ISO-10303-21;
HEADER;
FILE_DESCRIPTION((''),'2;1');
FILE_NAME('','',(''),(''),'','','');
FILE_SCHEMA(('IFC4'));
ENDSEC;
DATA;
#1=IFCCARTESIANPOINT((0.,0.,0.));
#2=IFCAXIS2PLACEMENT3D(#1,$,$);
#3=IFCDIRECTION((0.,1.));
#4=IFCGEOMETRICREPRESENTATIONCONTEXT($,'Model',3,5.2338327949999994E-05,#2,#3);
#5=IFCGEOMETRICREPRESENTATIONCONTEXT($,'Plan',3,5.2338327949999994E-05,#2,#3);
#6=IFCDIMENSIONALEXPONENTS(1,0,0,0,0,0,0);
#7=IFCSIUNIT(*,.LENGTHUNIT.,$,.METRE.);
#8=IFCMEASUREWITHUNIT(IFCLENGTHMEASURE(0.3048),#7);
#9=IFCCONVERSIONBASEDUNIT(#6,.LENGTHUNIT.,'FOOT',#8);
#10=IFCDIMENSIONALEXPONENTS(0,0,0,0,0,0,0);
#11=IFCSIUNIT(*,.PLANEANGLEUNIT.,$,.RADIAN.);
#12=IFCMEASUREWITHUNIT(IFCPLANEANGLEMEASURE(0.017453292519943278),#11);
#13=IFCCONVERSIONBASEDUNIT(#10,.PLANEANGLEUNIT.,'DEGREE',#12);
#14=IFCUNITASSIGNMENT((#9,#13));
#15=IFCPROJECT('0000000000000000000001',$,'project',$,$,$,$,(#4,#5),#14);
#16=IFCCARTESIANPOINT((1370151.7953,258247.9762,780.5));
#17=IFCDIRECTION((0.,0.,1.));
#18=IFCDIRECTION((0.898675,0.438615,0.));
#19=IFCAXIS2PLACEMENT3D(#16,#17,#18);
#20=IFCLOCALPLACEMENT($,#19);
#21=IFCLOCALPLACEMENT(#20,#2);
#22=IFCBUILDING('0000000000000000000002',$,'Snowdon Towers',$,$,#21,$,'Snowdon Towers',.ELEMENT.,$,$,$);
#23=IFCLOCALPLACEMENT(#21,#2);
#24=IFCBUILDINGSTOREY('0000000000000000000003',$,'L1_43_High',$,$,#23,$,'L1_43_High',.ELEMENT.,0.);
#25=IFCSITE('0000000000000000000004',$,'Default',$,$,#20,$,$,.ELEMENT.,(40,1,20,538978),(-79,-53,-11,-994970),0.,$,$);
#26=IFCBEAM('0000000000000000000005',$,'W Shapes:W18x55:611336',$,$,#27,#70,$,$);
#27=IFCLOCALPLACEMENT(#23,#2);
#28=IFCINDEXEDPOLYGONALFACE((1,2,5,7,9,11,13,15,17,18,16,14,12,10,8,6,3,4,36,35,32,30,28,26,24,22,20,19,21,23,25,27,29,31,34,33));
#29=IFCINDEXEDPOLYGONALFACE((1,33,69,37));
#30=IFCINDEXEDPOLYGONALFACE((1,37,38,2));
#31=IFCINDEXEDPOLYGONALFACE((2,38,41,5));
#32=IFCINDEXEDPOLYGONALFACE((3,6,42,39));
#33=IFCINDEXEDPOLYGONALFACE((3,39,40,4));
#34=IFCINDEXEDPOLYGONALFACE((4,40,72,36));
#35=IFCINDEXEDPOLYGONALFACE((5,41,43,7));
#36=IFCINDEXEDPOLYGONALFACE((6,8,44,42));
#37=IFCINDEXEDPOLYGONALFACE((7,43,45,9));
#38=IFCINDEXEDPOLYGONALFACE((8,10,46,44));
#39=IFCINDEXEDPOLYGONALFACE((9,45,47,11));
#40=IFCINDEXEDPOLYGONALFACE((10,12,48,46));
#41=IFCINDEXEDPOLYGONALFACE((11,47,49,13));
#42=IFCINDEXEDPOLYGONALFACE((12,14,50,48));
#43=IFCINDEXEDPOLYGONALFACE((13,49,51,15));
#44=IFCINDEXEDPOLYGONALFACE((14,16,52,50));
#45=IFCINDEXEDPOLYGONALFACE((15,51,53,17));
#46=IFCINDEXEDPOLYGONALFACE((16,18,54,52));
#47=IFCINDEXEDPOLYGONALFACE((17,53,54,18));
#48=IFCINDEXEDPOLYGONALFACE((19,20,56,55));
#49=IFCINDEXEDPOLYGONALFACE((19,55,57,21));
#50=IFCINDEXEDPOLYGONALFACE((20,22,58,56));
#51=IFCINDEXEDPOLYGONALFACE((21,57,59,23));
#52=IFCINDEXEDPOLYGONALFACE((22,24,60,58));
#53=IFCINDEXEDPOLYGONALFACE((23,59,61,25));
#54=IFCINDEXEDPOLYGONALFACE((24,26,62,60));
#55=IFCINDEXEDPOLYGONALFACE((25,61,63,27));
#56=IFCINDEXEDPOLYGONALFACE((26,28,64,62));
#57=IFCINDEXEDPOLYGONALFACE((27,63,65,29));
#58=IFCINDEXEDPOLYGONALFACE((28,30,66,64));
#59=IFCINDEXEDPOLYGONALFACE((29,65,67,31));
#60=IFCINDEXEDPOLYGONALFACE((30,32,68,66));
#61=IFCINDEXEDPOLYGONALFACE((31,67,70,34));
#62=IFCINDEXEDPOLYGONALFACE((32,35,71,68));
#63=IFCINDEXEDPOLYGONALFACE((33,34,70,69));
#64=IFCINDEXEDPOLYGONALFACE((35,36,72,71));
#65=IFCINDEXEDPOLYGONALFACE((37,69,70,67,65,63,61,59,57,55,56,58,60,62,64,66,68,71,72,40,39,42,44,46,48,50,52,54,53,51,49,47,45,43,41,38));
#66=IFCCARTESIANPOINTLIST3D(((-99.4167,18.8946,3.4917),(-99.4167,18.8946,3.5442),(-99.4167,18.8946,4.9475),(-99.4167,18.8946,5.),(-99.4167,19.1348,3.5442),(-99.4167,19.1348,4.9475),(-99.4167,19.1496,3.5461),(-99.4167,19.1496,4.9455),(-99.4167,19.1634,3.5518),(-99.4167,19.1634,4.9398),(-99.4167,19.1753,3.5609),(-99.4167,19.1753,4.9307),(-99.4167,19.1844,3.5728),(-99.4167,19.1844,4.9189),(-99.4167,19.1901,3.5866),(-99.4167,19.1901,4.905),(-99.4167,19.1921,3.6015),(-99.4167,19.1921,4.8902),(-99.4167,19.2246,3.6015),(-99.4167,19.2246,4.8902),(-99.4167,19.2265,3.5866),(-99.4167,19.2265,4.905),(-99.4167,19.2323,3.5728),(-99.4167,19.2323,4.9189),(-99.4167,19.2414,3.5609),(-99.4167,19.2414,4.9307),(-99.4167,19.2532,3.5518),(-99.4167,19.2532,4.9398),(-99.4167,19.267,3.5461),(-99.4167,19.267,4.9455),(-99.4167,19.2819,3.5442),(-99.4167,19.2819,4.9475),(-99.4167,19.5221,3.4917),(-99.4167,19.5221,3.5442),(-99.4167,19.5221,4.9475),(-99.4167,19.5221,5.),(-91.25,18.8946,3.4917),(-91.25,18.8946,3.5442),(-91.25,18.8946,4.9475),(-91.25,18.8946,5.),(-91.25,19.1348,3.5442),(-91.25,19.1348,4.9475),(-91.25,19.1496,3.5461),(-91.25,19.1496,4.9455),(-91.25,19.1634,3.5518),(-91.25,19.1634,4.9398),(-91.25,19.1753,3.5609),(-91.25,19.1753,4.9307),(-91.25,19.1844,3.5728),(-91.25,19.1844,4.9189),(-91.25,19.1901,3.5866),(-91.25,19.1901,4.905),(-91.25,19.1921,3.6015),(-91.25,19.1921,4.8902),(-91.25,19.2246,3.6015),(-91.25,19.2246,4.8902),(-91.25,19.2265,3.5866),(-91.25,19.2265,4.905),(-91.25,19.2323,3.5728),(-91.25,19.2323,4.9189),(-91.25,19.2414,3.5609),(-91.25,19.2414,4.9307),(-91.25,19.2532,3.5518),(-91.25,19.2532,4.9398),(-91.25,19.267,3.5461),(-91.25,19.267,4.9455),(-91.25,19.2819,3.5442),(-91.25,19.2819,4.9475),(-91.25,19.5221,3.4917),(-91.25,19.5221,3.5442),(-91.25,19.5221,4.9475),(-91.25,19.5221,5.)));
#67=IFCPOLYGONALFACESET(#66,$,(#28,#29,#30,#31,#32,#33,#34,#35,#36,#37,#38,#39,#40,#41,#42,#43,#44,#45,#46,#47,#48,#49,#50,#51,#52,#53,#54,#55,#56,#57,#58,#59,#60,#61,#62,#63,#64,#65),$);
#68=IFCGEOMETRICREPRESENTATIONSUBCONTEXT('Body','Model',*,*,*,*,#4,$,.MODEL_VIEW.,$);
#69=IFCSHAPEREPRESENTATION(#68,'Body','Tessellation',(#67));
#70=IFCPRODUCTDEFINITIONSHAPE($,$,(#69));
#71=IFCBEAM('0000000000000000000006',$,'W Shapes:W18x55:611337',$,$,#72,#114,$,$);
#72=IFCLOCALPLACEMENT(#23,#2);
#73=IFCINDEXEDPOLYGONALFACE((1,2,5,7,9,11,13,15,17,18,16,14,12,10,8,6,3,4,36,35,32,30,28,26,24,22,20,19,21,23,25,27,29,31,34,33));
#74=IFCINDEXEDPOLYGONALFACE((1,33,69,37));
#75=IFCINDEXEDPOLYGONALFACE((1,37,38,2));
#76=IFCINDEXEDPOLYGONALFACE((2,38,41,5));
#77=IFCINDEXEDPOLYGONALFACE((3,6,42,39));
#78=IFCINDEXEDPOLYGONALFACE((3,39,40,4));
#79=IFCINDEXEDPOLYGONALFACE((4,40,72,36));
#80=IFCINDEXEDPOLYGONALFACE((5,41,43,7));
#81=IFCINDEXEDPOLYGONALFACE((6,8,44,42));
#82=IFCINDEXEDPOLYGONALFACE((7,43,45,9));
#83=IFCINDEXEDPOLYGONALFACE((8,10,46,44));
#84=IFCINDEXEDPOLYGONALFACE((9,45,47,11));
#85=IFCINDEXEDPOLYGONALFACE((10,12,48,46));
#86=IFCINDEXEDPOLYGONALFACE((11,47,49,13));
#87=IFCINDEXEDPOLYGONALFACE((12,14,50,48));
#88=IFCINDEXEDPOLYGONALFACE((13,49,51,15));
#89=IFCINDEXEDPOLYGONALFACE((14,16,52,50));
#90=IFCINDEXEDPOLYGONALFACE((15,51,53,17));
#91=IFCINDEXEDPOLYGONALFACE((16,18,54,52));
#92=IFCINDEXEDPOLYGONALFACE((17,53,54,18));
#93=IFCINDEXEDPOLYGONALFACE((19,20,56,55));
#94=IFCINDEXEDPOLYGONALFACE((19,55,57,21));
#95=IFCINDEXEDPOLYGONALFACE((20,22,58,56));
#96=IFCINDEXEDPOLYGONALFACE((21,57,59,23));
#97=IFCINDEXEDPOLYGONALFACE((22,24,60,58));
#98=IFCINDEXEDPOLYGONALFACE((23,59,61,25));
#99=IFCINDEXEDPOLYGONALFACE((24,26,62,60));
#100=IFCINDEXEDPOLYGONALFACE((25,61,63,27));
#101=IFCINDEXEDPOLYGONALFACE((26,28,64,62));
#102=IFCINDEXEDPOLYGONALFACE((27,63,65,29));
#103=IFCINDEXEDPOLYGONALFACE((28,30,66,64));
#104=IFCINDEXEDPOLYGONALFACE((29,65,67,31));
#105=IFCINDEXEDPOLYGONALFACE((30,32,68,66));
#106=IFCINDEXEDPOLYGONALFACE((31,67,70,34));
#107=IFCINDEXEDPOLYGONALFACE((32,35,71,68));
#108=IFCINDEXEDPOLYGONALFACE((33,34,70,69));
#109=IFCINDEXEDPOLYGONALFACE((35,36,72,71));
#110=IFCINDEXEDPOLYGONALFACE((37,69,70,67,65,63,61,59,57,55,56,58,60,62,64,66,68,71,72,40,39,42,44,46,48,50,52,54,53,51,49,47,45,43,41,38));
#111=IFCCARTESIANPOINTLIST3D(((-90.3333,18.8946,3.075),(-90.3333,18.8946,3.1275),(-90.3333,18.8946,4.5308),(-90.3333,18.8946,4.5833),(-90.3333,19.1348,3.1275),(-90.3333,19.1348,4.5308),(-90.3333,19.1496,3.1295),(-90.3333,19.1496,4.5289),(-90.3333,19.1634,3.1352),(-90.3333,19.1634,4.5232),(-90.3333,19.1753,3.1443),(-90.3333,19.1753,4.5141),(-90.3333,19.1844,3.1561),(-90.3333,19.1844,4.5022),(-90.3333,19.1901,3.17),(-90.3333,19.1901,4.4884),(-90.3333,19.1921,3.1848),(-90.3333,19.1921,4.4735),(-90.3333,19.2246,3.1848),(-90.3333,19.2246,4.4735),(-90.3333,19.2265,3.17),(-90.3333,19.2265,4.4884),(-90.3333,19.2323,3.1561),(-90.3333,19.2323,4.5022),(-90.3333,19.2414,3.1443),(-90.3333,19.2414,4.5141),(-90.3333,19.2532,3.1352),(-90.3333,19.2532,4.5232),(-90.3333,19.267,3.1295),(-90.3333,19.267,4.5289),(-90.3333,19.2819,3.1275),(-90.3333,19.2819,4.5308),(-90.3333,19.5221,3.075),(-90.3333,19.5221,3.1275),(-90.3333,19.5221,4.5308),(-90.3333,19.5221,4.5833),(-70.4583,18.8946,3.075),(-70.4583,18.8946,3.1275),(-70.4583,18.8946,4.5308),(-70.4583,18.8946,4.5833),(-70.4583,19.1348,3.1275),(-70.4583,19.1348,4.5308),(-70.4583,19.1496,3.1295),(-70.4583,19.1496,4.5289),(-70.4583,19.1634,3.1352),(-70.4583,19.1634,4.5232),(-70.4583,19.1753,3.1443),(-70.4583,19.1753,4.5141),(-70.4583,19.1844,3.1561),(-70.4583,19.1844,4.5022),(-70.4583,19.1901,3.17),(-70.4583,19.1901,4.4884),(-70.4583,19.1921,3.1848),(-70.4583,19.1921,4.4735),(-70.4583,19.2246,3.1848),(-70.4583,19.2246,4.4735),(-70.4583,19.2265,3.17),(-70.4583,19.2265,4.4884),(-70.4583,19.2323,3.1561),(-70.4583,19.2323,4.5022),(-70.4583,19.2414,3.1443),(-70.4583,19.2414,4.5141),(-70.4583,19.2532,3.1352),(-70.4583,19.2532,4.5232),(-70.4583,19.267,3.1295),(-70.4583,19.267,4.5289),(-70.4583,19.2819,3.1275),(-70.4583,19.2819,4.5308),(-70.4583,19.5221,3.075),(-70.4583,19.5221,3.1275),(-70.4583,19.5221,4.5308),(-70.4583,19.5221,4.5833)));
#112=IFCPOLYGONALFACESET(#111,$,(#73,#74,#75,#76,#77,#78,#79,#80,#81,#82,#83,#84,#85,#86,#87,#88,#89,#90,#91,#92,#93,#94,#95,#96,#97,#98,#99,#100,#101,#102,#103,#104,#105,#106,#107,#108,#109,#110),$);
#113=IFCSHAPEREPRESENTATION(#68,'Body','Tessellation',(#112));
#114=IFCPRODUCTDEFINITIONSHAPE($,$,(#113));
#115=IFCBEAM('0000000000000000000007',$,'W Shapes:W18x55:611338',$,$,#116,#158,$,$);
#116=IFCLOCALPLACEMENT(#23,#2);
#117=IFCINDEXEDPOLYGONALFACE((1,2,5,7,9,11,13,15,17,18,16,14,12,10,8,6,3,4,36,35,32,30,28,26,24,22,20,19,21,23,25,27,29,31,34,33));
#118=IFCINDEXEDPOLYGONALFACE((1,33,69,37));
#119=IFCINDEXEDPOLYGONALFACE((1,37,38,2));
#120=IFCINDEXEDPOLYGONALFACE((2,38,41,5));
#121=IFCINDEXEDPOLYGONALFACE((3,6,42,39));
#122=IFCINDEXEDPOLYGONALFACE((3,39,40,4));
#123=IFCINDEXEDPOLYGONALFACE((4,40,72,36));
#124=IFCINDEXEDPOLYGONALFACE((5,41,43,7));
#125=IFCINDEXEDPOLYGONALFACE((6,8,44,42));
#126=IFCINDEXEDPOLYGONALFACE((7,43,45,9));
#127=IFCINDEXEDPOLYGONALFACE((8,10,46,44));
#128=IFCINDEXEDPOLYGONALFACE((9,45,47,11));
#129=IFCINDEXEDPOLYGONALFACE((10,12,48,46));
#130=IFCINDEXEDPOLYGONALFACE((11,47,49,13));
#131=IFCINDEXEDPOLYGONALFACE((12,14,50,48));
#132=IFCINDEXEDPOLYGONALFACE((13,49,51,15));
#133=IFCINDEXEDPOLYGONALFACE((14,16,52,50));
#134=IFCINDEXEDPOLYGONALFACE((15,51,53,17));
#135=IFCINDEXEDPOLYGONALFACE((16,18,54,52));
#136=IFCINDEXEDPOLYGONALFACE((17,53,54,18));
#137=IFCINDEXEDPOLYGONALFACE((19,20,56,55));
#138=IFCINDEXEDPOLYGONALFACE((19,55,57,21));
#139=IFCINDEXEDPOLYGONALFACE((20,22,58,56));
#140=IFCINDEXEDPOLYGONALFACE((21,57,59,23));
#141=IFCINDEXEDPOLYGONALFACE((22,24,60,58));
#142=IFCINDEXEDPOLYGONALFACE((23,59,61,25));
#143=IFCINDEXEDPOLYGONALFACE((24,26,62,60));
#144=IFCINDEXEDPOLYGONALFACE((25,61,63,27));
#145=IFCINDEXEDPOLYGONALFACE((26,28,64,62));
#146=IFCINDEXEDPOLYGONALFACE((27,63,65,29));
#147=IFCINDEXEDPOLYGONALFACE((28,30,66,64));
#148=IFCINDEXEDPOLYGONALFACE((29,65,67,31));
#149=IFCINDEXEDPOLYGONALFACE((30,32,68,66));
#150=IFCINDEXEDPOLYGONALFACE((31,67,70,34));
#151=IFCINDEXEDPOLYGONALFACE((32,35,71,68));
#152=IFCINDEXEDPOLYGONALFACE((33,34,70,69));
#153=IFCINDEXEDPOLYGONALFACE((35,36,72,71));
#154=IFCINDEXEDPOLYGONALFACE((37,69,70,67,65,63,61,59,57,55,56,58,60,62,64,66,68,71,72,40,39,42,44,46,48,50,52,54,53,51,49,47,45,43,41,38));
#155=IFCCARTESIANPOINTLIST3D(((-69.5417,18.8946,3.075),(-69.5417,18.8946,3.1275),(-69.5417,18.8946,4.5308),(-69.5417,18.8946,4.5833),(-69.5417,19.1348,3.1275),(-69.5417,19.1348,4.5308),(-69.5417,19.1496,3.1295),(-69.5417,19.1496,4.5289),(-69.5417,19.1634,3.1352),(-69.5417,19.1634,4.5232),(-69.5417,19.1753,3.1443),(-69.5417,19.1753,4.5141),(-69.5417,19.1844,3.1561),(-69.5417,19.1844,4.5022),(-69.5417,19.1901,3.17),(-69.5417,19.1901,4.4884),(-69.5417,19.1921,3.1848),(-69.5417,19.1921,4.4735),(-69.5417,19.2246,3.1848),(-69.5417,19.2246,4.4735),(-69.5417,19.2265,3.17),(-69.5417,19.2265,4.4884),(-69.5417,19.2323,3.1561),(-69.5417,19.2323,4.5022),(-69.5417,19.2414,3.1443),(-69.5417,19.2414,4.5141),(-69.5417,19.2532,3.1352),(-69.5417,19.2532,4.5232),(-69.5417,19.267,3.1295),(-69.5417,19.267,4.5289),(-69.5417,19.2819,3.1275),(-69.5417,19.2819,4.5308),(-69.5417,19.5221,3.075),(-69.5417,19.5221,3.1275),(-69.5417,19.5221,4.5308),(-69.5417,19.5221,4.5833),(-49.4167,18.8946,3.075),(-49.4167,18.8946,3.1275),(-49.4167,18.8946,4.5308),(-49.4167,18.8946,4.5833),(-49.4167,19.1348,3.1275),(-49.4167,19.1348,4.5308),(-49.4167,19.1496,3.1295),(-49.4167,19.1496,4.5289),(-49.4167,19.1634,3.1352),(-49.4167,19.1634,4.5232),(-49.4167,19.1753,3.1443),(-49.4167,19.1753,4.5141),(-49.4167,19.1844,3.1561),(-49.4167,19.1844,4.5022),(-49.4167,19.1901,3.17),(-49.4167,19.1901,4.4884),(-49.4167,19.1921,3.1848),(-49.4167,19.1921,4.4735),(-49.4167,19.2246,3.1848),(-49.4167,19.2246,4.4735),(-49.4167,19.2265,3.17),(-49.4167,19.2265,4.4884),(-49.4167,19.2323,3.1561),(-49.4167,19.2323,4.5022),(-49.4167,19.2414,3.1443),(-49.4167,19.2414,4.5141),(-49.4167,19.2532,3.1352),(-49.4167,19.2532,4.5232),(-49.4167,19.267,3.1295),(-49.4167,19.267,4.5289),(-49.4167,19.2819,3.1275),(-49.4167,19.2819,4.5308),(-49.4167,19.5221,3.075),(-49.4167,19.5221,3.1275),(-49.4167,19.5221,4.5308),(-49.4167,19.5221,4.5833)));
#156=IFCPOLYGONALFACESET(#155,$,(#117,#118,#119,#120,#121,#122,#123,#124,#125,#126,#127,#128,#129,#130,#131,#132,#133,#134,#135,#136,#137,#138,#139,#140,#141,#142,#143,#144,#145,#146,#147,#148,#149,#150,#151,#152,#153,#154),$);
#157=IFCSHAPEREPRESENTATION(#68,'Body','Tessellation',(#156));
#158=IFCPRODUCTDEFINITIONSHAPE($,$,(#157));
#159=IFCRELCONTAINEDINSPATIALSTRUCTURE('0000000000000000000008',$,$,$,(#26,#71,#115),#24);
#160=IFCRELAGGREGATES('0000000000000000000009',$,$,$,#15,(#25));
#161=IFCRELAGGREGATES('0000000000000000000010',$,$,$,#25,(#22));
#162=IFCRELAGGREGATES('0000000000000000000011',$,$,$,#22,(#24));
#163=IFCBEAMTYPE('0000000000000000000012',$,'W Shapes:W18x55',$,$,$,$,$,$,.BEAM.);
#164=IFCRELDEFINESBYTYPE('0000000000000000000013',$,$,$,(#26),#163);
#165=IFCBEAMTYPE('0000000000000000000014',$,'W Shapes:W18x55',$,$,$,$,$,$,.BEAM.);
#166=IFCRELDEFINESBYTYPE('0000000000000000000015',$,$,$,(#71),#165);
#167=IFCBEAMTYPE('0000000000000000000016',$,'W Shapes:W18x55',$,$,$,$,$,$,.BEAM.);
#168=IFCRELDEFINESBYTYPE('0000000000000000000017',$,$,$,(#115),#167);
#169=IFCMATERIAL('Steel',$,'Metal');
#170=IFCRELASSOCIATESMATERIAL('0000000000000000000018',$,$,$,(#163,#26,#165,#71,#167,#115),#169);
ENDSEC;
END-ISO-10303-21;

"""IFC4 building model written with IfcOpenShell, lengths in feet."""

from ifc_helpers import new_model, entity, si_unit, converted_unit, direction, frame, origin, place, context, subcontext, project, spatial, line, arc, indexed_curve, outline, extrude, source, transform, mapped, material, type_object, type_shapes, element, save


model = new_model("IFC4")

# Units and contexts
model_context = context("Model", 3, precision=5.2338327949999994e-05, world=origin(), true_north=direction((0.0, 1.0)))
plan_context = context("Plan", 3, precision=5.2338327949999994e-05, world=origin(), true_north=direction((0.0, 1.0)))
body_context = subcontext(model_context, "Body", "Model", "MODEL_VIEW")
ifc_project = project(units=[converted_unit("LENGTHUNIT", "FOOT", entity("IfcLengthMeasure", 0.3048), si_unit("LENGTHUNIT", "METRE"), dimensions=[1, 0, 0, 0, 0, 0, 0]), converted_unit("PLANEANGLEUNIT", "DEGREE", entity("IfcPlaneAngleMeasure", 0.017453292519943278), si_unit("PLANEANGLEUNIT", "RADIAN"), dimensions=[0, 0, 0, 0, 0, 0, 0])], contexts=[model_context, plan_context])

# Site, building, storey
site_placement = place(None, frame((1370151.7953, 258247.9762, 780.5), z_axis=(0.0, 0.0, 1.0), x_axis=(0.898675, 0.438615, 0.0)))
site = spatial("IfcSite", under=ifc_project, at=site_placement, Name="Default", CompositionType="ELEMENT", RefLatitude=(40, 1, 20, 538978), RefLongitude=(-79, -53, -11, -994970), RefElevation=0.0)
building_placement = place(site_placement, origin())
building = spatial("IfcBuilding", under=site, at=building_placement, Name="Snowdon Towers", LongName="Snowdon Towers", CompositionType="ELEMENT")
storey_placement = place(building_placement, origin())
storey = spatial("IfcBuildingStorey", under=building, at=storey_placement, Name="L1_43_High", LongName="L1_43_High", CompositionType="ELEMENT", Elevation=0.0)

# Shared definitions
ifc_material_1 = material(Name="Steel", Category="Metal")

# Beams
beam_type_1 = type_object("IfcBeamType", Name="W Shapes:W18x55", PredefinedType="BEAM", material=ifc_material_1)
shared_shape_1 = source(origin(), body_context, "Body", "SweptSolid", [
    extrude(outline(indexed_curve([(-0.7542, -0.3138), (-0.7017, -0.3138), (-0.7017, -0.0735), (-0.6849, -0.033), (-0.6444, -0.0162), (0.6444, -0.0162), (0.6849, -0.033), (0.7017, -0.0735), (0.7017, -0.3138), (0.7542, -0.3138), (0.7542, 0.3138), (0.7017, 0.3138), (0.7017, 0.0735), (0.6849, 0.033), (0.6444, 0.0163), (-0.6444, 0.0163), (-0.6849, 0.033), (-0.7017, 0.0735), (-0.7017, 0.3137), (-0.7542, 0.3137)], segments=[line(1, 2, 3), arc(3, 4, 5), line(5, 6), arc(6, 7, 8), line(8, 9, 10, 11, 12, 13), arc(13, 14, 15), line(15, 16), arc(16, 17, 18), line(18, 19, 20, 1)], self_intersect=False)), frame((-4.0417, 0.0, 0.0), z_axis=(1.0, 0.0, 0.0), x_axis=(0.0, 0.0, -1.0)), (0.0, 0.0, 1.0), 8.1667),
])
type_shapes(beam_type_1, [shared_shape_1])
beam_1_placement = place(storey_placement, frame((-95.375, 19.2083, 4.2458)))
element("IfcBeam", 1, at=beam_1_placement, inside=storey, type_object=beam_type_1, material=ifc_material_1, Name="W Shapes:W18x55:611336", context=body_context, shape_type="MappedRepresentation", body=[
    mapped(shared_shape_1, transform((0.0, 0.0, 0.0), scale=1.0)),
])
beam_type_2 = type_object("IfcBeamType", Name="W Shapes:W18x55", PredefinedType="BEAM", material=ifc_material_1)
shared_shape_2 = source(origin(), body_context, "Body", "SweptSolid", [
    extrude(outline(indexed_curve([(-0.7542, -0.3138), (-0.7017, -0.3138), (-0.7017, -0.0735), (-0.6849, -0.033), (-0.6444, -0.0162), (0.6444, -0.0162), (0.6849, -0.033), (0.7017, -0.0735), (0.7017, -0.3138), (0.7542, -0.3138), (0.7542, 0.3138), (0.7017, 0.3138), (0.7017, 0.0735), (0.6849, 0.033), (0.6444, 0.0163), (-0.6444, 0.0163), (-0.6849, 0.033), (-0.7017, 0.0735), (-0.7017, 0.3137), (-0.7542, 0.3137)], segments=[line(1, 2, 3), arc(3, 4, 5), line(5, 6), arc(6, 7, 8), line(8, 9, 10, 11, 12, 13), arc(13, 14, 15), line(15, 16), arc(16, 17, 18), line(18, 19, 20, 1)], self_intersect=False)), frame((-9.9375, 0.0, 0.0), z_axis=(1.0, 0.0, 0.0), x_axis=(0.0, 0.0, -1.0)), (0.0, 0.0, 1.0), 19.875),
])
type_shapes(beam_type_2, [shared_shape_2])
beam_2_placement = place(storey_placement, frame((-80.3958, 19.2083, 3.8292)))
element("IfcBeam", 2, at=beam_2_placement, inside=storey, type_object=beam_type_2, material=ifc_material_1, Name="W Shapes:W18x55:611337", context=body_context, shape_type="MappedRepresentation", body=[
    mapped(shared_shape_2, transform((0.0, 0.0, 0.0), scale=1.0)),
])
beam_type_3 = type_object("IfcBeamType", Name="W Shapes:W18x55", PredefinedType="BEAM", material=ifc_material_1)
shared_shape_3 = source(origin(), body_context, "Body", "SweptSolid", [
    extrude(outline(indexed_curve([(-0.7542, -0.3138), (-0.7017, -0.3138), (-0.7017, -0.0735), (-0.6849, -0.033), (-0.6444, -0.0162), (0.6444, -0.0162), (0.6849, -0.033), (0.7017, -0.0735), (0.7017, -0.3138), (0.7542, -0.3138), (0.7542, 0.3138), (0.7017, 0.3138), (0.7017, 0.0735), (0.6849, 0.033), (0.6444, 0.0163), (-0.6444, 0.0163), (-0.6849, 0.033), (-0.7017, 0.0735), (-0.7017, 0.3137), (-0.7542, 0.3137)], segments=[line(1, 2, 3), arc(3, 4, 5), line(5, 6), arc(6, 7, 8), line(8, 9, 10, 11, 12, 13), arc(13, 14, 15), line(15, 16), arc(16, 17, 18), line(18, 19, 20, 1)], self_intersect=False)), frame((-9.8333, 0.0, 0.0), z_axis=(1.0, 0.0, 0.0), x_axis=(0.0, 0.0, -1.0)), (0.0, 0.0, 1.0), 20.125),
])
type_shapes(beam_type_3, [shared_shape_3])
beam_3_placement = place(storey_placement, frame((-59.7083, 19.2083, 3.8292)))
element("IfcBeam", 3, at=beam_3_placement, inside=storey, type_object=beam_type_3, material=ifc_material_1, Name="W Shapes:W18x55:611338", context=body_context, shape_type="MappedRepresentation", body=[
    mapped(shared_shape_3, transform((0.0, 0.0, 0.0), scale=1.0)),
])

save(model, "model.ifc")
